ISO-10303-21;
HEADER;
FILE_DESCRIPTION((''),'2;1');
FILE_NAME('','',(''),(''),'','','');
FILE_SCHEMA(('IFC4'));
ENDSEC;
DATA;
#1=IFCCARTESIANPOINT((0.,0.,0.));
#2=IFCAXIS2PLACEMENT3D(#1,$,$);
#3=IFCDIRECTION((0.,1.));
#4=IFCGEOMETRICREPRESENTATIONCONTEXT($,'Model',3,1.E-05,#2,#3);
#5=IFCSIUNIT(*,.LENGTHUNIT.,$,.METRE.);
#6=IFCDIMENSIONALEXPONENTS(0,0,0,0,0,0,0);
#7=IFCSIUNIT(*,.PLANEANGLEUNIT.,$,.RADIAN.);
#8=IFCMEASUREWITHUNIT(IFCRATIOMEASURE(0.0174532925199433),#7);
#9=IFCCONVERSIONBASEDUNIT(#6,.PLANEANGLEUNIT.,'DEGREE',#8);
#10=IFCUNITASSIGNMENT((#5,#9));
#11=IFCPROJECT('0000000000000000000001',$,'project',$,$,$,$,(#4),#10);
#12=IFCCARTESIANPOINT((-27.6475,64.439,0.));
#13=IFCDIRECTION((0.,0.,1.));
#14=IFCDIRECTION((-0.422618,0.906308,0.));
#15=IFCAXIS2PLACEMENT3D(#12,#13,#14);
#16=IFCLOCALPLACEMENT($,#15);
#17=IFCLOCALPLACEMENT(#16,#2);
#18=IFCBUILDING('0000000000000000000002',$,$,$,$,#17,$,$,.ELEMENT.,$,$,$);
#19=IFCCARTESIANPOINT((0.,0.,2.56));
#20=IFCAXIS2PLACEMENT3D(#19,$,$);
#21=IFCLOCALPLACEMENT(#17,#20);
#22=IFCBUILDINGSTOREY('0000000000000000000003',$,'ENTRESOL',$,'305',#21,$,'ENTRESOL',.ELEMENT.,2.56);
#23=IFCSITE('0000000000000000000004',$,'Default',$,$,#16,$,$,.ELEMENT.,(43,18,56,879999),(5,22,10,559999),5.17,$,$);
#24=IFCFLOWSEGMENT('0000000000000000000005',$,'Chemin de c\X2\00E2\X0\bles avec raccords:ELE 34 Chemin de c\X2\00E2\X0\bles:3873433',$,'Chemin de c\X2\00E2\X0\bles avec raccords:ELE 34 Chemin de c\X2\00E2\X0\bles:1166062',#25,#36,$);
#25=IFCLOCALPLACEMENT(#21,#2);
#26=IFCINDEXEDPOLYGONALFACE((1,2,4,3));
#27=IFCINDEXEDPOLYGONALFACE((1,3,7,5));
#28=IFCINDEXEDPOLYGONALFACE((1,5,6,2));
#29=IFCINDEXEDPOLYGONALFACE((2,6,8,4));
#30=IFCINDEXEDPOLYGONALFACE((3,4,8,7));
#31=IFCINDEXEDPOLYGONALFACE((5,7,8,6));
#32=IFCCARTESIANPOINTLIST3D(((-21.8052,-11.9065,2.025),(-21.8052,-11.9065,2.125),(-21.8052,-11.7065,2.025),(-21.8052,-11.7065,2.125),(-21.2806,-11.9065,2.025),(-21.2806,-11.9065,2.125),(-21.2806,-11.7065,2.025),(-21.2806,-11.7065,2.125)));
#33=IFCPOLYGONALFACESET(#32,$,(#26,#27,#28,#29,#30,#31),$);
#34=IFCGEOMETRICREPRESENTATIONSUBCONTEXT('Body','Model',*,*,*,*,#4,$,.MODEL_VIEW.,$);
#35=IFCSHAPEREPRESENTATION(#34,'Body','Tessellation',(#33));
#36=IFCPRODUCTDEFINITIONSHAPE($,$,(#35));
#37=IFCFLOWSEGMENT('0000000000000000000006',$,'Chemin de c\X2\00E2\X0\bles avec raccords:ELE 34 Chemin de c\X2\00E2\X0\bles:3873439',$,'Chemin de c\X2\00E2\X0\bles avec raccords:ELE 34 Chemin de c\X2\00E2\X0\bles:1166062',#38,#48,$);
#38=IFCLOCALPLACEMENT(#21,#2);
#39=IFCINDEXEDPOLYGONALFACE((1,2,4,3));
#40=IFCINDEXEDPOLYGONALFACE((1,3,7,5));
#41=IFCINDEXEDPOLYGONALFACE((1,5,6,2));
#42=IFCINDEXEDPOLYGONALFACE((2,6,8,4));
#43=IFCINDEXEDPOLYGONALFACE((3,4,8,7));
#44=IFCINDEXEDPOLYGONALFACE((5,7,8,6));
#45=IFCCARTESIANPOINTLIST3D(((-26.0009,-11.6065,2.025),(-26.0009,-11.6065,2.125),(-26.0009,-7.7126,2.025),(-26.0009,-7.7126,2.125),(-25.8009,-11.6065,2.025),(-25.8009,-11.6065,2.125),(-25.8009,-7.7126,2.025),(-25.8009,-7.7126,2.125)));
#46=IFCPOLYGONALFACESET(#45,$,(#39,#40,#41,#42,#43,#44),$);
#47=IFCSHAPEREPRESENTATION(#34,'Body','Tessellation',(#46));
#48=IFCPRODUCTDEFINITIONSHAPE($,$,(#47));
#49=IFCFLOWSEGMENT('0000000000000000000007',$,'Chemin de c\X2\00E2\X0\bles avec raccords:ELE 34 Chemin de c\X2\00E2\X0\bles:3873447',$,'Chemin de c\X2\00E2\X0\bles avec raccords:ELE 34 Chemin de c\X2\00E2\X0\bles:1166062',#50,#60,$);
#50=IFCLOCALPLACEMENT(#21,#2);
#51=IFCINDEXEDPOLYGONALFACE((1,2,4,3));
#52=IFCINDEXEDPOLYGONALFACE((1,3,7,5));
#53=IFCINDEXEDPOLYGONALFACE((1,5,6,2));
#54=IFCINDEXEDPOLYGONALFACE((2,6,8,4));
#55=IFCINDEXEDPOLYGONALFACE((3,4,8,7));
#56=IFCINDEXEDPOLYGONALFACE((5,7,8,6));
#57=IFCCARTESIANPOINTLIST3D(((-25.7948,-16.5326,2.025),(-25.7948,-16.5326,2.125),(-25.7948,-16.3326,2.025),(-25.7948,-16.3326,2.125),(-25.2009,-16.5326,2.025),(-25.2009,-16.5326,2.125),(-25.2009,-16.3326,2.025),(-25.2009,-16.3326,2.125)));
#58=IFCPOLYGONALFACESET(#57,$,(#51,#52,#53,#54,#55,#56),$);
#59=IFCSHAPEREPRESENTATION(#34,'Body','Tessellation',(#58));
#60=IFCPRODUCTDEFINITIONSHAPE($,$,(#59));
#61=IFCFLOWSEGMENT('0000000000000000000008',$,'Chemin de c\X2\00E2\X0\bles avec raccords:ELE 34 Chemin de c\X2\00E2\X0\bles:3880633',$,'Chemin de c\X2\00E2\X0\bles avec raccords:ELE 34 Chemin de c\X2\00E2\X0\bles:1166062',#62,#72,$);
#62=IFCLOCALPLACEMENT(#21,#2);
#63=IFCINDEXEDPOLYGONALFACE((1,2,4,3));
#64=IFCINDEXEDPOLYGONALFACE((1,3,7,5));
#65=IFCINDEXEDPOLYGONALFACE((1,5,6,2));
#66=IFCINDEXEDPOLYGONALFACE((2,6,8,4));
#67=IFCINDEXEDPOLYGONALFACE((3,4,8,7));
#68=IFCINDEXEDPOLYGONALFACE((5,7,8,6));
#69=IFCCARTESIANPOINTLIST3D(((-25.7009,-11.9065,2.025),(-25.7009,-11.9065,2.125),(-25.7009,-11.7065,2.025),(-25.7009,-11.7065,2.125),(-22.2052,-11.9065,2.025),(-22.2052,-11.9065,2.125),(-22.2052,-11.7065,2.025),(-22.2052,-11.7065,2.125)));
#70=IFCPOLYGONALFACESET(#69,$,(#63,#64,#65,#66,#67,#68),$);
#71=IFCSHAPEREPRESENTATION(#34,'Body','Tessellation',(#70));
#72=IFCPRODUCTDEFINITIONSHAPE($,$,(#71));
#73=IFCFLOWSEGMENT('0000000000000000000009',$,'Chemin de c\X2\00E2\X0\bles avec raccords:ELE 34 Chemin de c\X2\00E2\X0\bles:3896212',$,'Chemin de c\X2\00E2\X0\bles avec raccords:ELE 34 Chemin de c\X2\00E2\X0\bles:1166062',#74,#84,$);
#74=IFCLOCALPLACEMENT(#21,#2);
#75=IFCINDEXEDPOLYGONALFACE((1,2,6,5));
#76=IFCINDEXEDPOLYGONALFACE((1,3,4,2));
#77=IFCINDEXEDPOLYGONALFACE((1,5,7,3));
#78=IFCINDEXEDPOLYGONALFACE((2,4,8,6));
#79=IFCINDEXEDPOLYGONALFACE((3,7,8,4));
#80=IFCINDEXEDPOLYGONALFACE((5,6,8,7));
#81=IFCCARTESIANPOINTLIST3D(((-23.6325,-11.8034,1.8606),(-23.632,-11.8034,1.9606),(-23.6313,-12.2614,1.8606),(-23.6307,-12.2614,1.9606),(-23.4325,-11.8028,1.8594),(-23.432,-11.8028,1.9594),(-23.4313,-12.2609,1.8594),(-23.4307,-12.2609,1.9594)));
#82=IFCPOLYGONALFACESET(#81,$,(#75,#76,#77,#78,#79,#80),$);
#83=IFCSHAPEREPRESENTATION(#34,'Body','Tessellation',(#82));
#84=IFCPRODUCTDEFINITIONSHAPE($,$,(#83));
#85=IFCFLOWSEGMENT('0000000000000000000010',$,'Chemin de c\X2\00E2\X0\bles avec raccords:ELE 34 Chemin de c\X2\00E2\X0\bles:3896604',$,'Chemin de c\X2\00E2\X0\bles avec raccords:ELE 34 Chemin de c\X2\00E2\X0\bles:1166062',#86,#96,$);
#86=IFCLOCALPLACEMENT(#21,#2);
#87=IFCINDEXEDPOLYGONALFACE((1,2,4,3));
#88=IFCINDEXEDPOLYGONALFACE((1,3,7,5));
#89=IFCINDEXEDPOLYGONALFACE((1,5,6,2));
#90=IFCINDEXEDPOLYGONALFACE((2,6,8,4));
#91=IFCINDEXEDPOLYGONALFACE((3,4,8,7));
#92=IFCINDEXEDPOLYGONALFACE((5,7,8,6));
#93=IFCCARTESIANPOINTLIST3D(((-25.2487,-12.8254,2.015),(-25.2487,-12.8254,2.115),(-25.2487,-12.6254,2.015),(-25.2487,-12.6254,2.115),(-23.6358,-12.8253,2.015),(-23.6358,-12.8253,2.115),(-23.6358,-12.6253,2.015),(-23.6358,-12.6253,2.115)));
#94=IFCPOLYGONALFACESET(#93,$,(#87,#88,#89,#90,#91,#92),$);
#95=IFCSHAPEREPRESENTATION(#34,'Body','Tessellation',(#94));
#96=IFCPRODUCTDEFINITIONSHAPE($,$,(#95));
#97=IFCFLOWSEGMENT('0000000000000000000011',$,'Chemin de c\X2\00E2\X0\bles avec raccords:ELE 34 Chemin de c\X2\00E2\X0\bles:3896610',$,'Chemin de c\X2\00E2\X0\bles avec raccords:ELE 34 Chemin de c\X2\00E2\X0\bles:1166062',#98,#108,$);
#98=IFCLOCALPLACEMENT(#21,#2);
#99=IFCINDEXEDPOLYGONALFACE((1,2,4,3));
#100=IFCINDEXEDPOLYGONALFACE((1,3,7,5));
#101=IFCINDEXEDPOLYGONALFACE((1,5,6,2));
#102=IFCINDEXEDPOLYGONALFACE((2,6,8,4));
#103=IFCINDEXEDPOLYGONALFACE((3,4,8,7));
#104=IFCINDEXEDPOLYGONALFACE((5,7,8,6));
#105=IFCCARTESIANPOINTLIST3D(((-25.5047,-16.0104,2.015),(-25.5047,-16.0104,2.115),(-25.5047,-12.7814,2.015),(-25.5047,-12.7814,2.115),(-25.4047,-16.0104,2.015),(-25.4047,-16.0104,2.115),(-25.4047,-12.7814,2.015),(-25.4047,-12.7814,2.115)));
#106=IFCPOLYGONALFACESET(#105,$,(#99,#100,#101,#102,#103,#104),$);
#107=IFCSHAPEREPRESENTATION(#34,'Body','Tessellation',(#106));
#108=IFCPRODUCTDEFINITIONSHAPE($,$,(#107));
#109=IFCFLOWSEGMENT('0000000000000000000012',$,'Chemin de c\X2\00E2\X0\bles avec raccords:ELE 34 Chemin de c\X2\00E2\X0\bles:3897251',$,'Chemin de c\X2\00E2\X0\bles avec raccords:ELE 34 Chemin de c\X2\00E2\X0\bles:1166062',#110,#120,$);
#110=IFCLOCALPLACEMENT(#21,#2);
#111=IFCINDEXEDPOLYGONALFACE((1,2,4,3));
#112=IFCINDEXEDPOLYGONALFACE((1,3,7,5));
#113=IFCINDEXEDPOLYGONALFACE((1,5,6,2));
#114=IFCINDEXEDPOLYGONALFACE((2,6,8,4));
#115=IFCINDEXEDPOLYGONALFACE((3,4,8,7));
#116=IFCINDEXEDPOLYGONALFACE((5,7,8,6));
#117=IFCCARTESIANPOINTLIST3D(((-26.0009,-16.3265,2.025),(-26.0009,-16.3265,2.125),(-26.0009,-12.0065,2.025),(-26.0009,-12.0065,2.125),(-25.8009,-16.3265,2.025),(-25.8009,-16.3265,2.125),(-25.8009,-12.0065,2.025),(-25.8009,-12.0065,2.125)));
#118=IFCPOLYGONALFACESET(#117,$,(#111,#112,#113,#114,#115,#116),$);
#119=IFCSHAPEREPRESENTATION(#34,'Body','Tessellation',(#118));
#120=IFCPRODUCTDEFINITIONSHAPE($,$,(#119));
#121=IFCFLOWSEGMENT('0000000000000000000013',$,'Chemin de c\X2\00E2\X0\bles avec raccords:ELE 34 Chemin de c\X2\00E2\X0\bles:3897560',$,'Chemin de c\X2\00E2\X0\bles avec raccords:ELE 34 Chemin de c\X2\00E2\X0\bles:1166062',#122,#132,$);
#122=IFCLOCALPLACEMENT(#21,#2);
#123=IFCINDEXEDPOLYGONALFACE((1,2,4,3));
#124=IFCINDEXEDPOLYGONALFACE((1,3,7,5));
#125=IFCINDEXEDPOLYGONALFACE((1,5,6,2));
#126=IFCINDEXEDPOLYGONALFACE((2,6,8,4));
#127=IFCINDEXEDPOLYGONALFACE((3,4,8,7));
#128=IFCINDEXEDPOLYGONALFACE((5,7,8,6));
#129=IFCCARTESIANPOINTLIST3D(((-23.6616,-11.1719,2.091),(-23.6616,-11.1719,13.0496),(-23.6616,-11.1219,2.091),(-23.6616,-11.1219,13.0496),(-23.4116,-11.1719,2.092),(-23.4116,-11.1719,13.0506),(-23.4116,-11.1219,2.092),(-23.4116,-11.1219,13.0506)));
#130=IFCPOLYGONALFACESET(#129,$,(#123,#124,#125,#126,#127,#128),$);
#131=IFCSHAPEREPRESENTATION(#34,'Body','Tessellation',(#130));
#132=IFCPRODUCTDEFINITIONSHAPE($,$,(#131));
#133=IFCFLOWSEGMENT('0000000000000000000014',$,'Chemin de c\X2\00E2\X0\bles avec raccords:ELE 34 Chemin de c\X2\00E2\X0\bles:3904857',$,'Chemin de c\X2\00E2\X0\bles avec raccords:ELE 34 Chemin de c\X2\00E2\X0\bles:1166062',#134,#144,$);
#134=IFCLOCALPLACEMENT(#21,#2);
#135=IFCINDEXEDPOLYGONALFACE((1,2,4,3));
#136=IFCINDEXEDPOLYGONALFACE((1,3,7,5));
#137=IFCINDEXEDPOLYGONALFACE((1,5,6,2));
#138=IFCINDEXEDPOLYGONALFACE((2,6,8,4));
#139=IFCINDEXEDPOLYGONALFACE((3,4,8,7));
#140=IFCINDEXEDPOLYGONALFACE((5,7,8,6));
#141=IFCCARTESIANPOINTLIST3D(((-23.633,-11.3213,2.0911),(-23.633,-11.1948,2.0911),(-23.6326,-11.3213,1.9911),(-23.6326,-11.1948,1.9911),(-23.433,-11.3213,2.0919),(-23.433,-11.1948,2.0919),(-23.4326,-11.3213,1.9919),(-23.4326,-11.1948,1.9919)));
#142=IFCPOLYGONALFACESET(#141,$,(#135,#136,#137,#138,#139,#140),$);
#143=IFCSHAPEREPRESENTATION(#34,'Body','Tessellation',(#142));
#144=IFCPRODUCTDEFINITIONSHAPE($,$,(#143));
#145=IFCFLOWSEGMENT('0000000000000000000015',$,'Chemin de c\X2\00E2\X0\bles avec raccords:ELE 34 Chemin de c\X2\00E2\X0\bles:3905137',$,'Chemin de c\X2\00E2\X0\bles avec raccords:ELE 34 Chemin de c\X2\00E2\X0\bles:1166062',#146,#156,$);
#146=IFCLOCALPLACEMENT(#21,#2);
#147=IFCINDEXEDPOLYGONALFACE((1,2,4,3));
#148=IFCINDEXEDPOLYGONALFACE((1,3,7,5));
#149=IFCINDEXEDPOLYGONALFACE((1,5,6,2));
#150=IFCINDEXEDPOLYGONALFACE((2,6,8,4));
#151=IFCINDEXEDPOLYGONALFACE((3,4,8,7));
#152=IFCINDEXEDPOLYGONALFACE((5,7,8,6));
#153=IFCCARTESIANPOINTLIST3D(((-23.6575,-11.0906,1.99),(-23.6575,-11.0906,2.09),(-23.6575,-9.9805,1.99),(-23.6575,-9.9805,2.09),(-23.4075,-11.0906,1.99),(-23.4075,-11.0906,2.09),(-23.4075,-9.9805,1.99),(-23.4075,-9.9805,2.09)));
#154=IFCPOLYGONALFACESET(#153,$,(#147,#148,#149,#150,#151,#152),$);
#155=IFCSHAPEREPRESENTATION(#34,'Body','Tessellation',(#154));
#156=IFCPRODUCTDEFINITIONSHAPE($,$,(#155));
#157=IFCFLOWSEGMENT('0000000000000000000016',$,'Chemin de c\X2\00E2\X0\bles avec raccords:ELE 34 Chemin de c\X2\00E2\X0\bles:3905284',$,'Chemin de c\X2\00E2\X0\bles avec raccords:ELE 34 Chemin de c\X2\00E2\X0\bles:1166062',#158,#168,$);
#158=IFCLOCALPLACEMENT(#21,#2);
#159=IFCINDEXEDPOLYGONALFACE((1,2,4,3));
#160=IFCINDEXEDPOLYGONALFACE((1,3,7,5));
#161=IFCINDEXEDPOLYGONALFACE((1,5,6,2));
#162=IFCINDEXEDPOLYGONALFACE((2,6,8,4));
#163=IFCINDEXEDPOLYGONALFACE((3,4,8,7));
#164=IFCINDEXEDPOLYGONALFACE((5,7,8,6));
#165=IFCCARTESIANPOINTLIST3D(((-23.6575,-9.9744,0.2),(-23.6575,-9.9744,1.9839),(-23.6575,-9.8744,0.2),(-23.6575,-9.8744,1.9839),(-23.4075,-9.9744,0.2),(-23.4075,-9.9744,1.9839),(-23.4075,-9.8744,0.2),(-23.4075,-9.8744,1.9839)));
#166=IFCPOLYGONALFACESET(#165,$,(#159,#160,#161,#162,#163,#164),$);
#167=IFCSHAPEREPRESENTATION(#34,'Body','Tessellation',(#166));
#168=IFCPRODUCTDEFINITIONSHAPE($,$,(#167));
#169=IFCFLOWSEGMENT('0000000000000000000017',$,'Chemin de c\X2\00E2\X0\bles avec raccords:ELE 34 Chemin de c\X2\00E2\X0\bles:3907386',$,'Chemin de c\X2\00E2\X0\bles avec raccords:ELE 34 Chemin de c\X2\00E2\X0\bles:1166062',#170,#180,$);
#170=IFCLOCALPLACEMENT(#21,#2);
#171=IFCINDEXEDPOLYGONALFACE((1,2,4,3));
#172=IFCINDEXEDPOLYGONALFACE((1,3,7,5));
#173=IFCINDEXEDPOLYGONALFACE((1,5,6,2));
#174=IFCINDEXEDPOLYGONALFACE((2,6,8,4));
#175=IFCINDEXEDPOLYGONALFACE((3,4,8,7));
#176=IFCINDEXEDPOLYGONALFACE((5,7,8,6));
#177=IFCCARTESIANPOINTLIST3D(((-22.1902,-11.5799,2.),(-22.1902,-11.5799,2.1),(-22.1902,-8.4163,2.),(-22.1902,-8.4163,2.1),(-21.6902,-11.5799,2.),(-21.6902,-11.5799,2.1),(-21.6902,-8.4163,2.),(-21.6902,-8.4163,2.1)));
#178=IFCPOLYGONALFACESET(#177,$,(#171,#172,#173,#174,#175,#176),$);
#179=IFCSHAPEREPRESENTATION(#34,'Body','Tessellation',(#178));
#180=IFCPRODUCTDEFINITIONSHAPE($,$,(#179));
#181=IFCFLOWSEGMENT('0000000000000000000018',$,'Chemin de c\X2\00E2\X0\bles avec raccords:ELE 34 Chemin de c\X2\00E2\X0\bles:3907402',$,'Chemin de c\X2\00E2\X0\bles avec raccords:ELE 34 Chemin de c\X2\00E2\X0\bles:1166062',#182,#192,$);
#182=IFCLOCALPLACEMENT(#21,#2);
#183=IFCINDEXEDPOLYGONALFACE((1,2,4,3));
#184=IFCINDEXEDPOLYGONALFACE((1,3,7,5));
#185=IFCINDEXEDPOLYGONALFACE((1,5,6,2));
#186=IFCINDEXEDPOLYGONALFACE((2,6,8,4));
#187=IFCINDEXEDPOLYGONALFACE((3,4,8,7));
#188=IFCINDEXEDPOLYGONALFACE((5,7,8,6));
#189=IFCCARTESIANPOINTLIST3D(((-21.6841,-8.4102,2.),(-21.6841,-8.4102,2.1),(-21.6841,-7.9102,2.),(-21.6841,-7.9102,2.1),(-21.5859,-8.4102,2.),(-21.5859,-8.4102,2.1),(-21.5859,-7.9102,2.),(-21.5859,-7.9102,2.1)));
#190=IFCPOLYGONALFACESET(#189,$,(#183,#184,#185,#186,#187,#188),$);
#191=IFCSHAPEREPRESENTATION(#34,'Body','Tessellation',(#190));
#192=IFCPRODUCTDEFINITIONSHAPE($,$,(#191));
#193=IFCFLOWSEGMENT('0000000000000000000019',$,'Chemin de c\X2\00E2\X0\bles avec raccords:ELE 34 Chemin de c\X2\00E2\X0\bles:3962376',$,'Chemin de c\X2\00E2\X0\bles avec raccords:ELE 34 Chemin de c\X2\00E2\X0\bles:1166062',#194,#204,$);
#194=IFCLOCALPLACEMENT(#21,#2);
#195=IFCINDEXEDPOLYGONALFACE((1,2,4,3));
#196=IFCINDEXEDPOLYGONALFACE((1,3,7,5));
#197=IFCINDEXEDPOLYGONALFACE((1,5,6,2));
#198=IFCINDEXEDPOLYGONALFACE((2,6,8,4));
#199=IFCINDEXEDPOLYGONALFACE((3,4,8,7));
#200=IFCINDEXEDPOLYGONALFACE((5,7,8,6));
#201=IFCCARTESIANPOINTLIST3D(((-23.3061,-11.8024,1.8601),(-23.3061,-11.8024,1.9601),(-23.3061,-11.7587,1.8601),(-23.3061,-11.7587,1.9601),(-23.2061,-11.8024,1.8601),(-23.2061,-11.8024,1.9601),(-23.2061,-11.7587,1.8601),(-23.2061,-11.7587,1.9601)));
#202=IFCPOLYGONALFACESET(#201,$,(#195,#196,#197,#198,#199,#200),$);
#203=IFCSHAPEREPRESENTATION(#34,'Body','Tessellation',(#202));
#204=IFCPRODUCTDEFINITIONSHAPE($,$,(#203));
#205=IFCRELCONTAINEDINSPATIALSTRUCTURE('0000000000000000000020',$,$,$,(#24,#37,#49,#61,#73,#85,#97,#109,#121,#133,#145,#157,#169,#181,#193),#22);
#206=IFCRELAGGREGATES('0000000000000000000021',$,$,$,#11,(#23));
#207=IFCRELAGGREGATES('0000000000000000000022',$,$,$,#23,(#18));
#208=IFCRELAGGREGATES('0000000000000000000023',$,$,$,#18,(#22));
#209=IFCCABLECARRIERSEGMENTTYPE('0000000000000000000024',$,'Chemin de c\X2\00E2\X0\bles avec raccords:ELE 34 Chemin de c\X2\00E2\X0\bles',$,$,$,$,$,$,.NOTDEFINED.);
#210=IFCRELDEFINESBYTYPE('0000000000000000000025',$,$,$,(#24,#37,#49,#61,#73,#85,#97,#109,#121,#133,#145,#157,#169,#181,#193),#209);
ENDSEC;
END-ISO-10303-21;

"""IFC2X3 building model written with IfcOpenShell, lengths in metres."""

from ifc_helpers import new_model, entity, si_unit, converted_unit, direction, frame, frame_2d, origin, origin_2d_with_axis, place, context, subcontext, project, spatial, rectangle, extrude, type_object, element, save


model = new_model("IFC2X3")

# Units and contexts
model_context = context("Model", 3, precision=1e-05, world=origin(), true_north=direction((0.0, 1.0)))
body_context = subcontext(model_context, "Body", "Model", "MODEL_VIEW")
ifc_project = project(units=[si_unit("LENGTHUNIT", "METRE"), converted_unit("PLANEANGLEUNIT", "DEGREE", entity("IfcRatioMeasure", 0.0174532925199433), si_unit("PLANEANGLEUNIT", "RADIAN"), dimensions=[0, 0, 0, 0, 0, 0, 0])], contexts=[model_context])

# Site, building, storey
site_placement = place(None, frame((-27.6475, 64.439, 0.0), z_axis=(0.0, 0.0, 1.0), x_axis=(-0.422618, 0.906308, 0.0)))
site = spatial("IfcSite", under=ifc_project, at=site_placement, Name="Default", CompositionType="ELEMENT", RefLatitude=(43, 18, 56, 879999), RefLongitude=(5, 22, 10, 559999), RefElevation=5.17)
building_placement = place(site_placement, origin())
building = spatial("IfcBuilding", under=site, at=building_placement, CompositionType="ELEMENT")
storey_placement = place(building_placement, frame((0.0, 0.0, 2.56)))
storey = spatial("IfcBuildingStorey", under=building, at=storey_placement, Name="ENTRESOL", ObjectType="305", LongName="ENTRESOL", CompositionType="ELEMENT", Elevation=2.56)

# Flow segments
cable_carrier_segment_type = type_object("IfcCableCarrierSegmentType", Name="Chemin de câbles avec raccords:ELE 34 Chemin de câbles", PredefinedType="NOTDEFINED")
flow_segment_1_placement = place(storey_placement, origin())
element("IfcFlowSegment", 1, at=flow_segment_1_placement, inside=storey, type_object=cable_carrier_segment_type, Name="Chemin de câbles avec raccords:ELE 34 Chemin de câbles:3873433", ObjectType="Chemin de câbles avec raccords:ELE 34 Chemin de câbles:1166062", context=body_context, shape_type="SweptSolid", body=[
    extrude(rectangle(XDim=0.5246, YDim=0.2, at=frame_2d((0.0, 0.0), x_axis=(1.0, 0.0))), frame((-21.5429, -11.8065, 2.025), z_axis=(-0.000071, 0.0, 1.0), x_axis=(1.0, 0.0, 0.000071)), (0.0, 0.0, 1.0), 0.1),
])
flow_segment_2_placement = place(storey_placement, origin())
element("IfcFlowSegment", 2, at=flow_segment_2_placement, inside=storey, type_object=cable_carrier_segment_type, Name="Chemin de câbles avec raccords:ELE 34 Chemin de câbles:3873439", ObjectType="Chemin de câbles avec raccords:ELE 34 Chemin de câbles:1166062", context=body_context, shape_type="SweptSolid", body=[
    extrude(rectangle(XDim=3.8939, YDim=0.2, at=origin_2d_with_axis()), frame((-25.9009, -9.6595, 2.025), z_axis=(0.0, 0.0, 1.0), x_axis=(0.0, 1.0, 0.0)), (0.0, 0.0, 1.0), 0.1),
])
flow_segment_3_placement = place(storey_placement, origin())
element("IfcFlowSegment", 3, at=flow_segment_3_placement, inside=storey, type_object=cable_carrier_segment_type, Name="Chemin de câbles avec raccords:ELE 34 Chemin de câbles:3873447", ObjectType="Chemin de câbles avec raccords:ELE 34 Chemin de câbles:1166062", context=body_context, shape_type="SweptSolid", body=[
    extrude(rectangle(XDim=0.5939, YDim=0.2, at=frame_2d((0.0, 0.0), x_axis=(1.0, 0.0))), frame((-25.4979, -16.4326, 2.025)), (0.0, 0.0, 1.0), 0.1),
])
flow_segment_4_placement = place(storey_placement, origin())
element("IfcFlowSegment", 4, at=flow_segment_4_placement, inside=storey, type_object=cable_carrier_segment_type, Name="Chemin de câbles avec raccords:ELE 34 Chemin de câbles:3880633", ObjectType="Chemin de câbles avec raccords:ELE 34 Chemin de câbles:1166062", context=body_context, shape_type="SweptSolid", body=[
    extrude(rectangle(XDim=3.4957, YDim=0.2, at=frame_2d((0.0, 0.0), x_axis=(1.0, 0.0))), frame((-23.9531, -11.8065, 2.025), z_axis=(0.000008, 0.0, 1.0), x_axis=(-1.0, 0.0, 0.000008)), (0.0, 0.0, 1.0), 0.1),
])
flow_segment_5_placement = place(storey_placement, origin())
element("IfcFlowSegment", 5, at=flow_segment_5_placement, inside=storey, type_object=cable_carrier_segment_type, Name="Chemin de câbles avec raccords:ELE 34 Chemin de câbles:3896212", ObjectType="Chemin de câbles avec raccords:ELE 34 Chemin de câbles:1166062", context=body_context, shape_type="SweptSolid", body=[
    extrude(rectangle(XDim=0.1, YDim=0.2, at=origin_2d_with_axis()), frame((-23.531, -12.2612, 1.91), z_axis=(-0.002796, 0.999996, 0.0), x_axis=(0.005751, 0.000016, 0.999983)), (0.0, 0.0, 1.0), 0.4581),
])
flow_segment_6_placement = place(storey_placement, origin())
element("IfcFlowSegment", 6, at=flow_segment_6_placement, inside=storey, type_object=cable_carrier_segment_type, Name="Chemin de câbles avec raccords:ELE 34 Chemin de câbles:3896604", ObjectType="Chemin de câbles avec raccords:ELE 34 Chemin de câbles:1166062", context=body_context, shape_type="SweptSolid", body=[
    extrude(rectangle(XDim=1.6128, YDim=0.2, at=frame_2d((0.0, 0.0), x_axis=(1.0, 0.0))), frame((-24.4422, -12.7253, 2.015), z_axis=(-0.000009, 0.0, 1.0), x_axis=(-1.0, -0.000009, -0.000009)), (0.0, 0.0, 1.0), 0.1),
])
flow_segment_7_placement = place(storey_placement, origin())
element("IfcFlowSegment", 7, at=flow_segment_7_placement, inside=storey, type_object=cable_carrier_segment_type, Name="Chemin de câbles avec raccords:ELE 34 Chemin de câbles:3896610", ObjectType="Chemin de câbles avec raccords:ELE 34 Chemin de câbles:1166062", context=body_context, shape_type="SweptSolid", body=[
    extrude(rectangle(XDim=3.2289, YDim=0.1, at=frame_2d((0.0, 0.0), x_axis=(1.0, 0.0))), frame((-25.4547, -14.3959, 2.015), z_axis=(0.0, 0.0, 1.0), x_axis=(0.0, -1.0, 0.0)), (0.0, 0.0, 1.0), 0.1),
])
flow_segment_8_placement = place(storey_placement, origin())
element("IfcFlowSegment", 8, at=flow_segment_8_placement, inside=storey, type_object=cable_carrier_segment_type, Name="Chemin de câbles avec raccords:ELE 34 Chemin de câbles:3897251", ObjectType="Chemin de câbles avec raccords:ELE 34 Chemin de câbles:1166062", context=body_context, shape_type="SweptSolid", body=[
    extrude(rectangle(XDim=4.3201, YDim=0.2, at=origin_2d_with_axis()), frame((-25.9009, -14.1665, 2.025), z_axis=(0.0, 0.0, 1.0), x_axis=(0.0, 1.0, 0.0)), (0.0, 0.0, 1.0), 0.1),
])
flow_segment_9_placement = place(storey_placement, origin())
element("IfcFlowSegment", 9, at=flow_segment_9_placement, inside=storey, type_object=cable_carrier_segment_type, Name="Chemin de câbles avec raccords:ELE 34 Chemin de câbles:3897560", ObjectType="Chemin de câbles avec raccords:ELE 34 Chemin de câbles:1166062", context=body_context, shape_type="SweptSolid", body=[
    extrude(rectangle(XDim=0.25, YDim=0.05, at=origin_2d_with_axis()), frame((-23.5366, -11.1469, 2.0915), z_axis=(-0.004126, 0.0, 0.999991), x_axis=(0.999991, -0.000012, 0.004126)), (0.004126, 0.0, 0.999991), 10.9586),
])
flow_segment_10_placement = place(storey_placement, origin())
element("IfcFlowSegment", 10, at=flow_segment_10_placement, inside=storey, type_object=cable_carrier_segment_type, Name="Chemin de câbles avec raccords:ELE 34 Chemin de câbles:3904857", ObjectType="Chemin de câbles avec raccords:ELE 34 Chemin de câbles:1166062", context=body_context, shape_type="SweptSolid", body=[
    extrude(rectangle(XDim=0.2, YDim=0.1265, at=frame_2d((0.0, 0.0), x_axis=(0.0, 1.0))), frame((-23.5326, -11.258, 1.9915), z_axis=(-0.004126, 0.0, 0.999991), x_axis=(0.0, 1.0, 0.0)), (0.0, 0.0, 1.0), 0.1),
])
flow_segment_11_placement = place(storey_placement, origin())
element("IfcFlowSegment", 11, at=flow_segment_11_placement, inside=storey, type_object=cable_carrier_segment_type, Name="Chemin de câbles avec raccords:ELE 34 Chemin de câbles:3905137", ObjectType="Chemin de câbles avec raccords:ELE 34 Chemin de câbles:1166062", context=body_context, shape_type="SweptSolid", body=[
    extrude(rectangle(XDim=1.1101, YDim=0.25, at=frame_2d((0.0, 0.0), x_axis=(1.0, 0.0))), frame((-23.5325, -10.5356, 1.99), z_axis=(0.0, 0.0, 1.0), x_axis=(0.0, 1.0, 0.0)), (0.0, 0.0, 1.0), 0.1),
])
flow_segment_12_placement = place(storey_placement, origin())
element("IfcFlowSegment", 12, at=flow_segment_12_placement, inside=storey, type_object=cable_carrier_segment_type, Name="Chemin de câbles avec raccords:ELE 34 Chemin de câbles:3905284", ObjectType="Chemin de câbles avec raccords:ELE 34 Chemin de câbles:1166062", context=body_context, shape_type="SweptSolid", body=[
    extrude(rectangle(XDim=0.1, YDim=0.25, at=origin_2d_with_axis()), frame((-23.5325, -9.9244, 0.2), z_axis=(0.0, 0.0, 1.0), x_axis=(0.0, 1.0, 0.0)), (0.0, 0.0, 1.0), 1.7839),
])
flow_segment_13_placement = place(storey_placement, origin())
element("IfcFlowSegment", 13, at=flow_segment_13_placement, inside=storey, type_object=cable_carrier_segment_type, Name="Chemin de câbles avec raccords:ELE 34 Chemin de câbles:3907386", ObjectType="Chemin de câbles avec raccords:ELE 34 Chemin de câbles:1166062", context=body_context, shape_type="SweptSolid", body=[
    extrude(rectangle(XDim=3.1636, YDim=0.5, at=frame_2d((0.0, 0.0), x_axis=(1.0, 0.0))), frame((-21.9402, -9.9981, 2.0), z_axis=(0.0, 0.0, 1.0), x_axis=(0.0, 1.0, 0.0)), (0.0, 0.0, 1.0), 0.1),
])
flow_segment_14_placement = place(storey_placement, origin())
element("IfcFlowSegment", 14, at=flow_segment_14_placement, inside=storey, type_object=cable_carrier_segment_type, Name="Chemin de câbles avec raccords:ELE 34 Chemin de câbles:3907402", ObjectType="Chemin de câbles avec raccords:ELE 34 Chemin de câbles:1166062", context=body_context, shape_type="SweptSolid", body=[
    extrude(rectangle(XDim=0.0982, YDim=0.5, at=frame_2d((0.0, 0.0), x_axis=(1.0, 0.0))), frame((-21.635, -8.1602, 2.0)), (0.0, 0.0, 1.0), 0.1),
])
flow_segment_15_placement = place(storey_placement, origin())
element("IfcFlowSegment", 15, at=flow_segment_15_placement, inside=storey, type_object=cable_carrier_segment_type, Name="Chemin de câbles avec raccords:ELE 34 Chemin de câbles:3962376", ObjectType="Chemin de câbles avec raccords:ELE 34 Chemin de câbles:1166062", context=body_context, shape_type="SweptSolid", body=[
    extrude(rectangle(XDim=0.1, YDim=0.0437, at=frame_2d((0.0, 0.0), x_axis=(0.0, 1.0))), frame((-23.2561, -11.7805, 1.8601), z_axis=(0.000195, 0.0, 1.0), x_axis=(-0.000021, -1.0, 0.0)), (0.0, 0.0, 1.0), 0.1),
])

save(model, "model.ifc")
